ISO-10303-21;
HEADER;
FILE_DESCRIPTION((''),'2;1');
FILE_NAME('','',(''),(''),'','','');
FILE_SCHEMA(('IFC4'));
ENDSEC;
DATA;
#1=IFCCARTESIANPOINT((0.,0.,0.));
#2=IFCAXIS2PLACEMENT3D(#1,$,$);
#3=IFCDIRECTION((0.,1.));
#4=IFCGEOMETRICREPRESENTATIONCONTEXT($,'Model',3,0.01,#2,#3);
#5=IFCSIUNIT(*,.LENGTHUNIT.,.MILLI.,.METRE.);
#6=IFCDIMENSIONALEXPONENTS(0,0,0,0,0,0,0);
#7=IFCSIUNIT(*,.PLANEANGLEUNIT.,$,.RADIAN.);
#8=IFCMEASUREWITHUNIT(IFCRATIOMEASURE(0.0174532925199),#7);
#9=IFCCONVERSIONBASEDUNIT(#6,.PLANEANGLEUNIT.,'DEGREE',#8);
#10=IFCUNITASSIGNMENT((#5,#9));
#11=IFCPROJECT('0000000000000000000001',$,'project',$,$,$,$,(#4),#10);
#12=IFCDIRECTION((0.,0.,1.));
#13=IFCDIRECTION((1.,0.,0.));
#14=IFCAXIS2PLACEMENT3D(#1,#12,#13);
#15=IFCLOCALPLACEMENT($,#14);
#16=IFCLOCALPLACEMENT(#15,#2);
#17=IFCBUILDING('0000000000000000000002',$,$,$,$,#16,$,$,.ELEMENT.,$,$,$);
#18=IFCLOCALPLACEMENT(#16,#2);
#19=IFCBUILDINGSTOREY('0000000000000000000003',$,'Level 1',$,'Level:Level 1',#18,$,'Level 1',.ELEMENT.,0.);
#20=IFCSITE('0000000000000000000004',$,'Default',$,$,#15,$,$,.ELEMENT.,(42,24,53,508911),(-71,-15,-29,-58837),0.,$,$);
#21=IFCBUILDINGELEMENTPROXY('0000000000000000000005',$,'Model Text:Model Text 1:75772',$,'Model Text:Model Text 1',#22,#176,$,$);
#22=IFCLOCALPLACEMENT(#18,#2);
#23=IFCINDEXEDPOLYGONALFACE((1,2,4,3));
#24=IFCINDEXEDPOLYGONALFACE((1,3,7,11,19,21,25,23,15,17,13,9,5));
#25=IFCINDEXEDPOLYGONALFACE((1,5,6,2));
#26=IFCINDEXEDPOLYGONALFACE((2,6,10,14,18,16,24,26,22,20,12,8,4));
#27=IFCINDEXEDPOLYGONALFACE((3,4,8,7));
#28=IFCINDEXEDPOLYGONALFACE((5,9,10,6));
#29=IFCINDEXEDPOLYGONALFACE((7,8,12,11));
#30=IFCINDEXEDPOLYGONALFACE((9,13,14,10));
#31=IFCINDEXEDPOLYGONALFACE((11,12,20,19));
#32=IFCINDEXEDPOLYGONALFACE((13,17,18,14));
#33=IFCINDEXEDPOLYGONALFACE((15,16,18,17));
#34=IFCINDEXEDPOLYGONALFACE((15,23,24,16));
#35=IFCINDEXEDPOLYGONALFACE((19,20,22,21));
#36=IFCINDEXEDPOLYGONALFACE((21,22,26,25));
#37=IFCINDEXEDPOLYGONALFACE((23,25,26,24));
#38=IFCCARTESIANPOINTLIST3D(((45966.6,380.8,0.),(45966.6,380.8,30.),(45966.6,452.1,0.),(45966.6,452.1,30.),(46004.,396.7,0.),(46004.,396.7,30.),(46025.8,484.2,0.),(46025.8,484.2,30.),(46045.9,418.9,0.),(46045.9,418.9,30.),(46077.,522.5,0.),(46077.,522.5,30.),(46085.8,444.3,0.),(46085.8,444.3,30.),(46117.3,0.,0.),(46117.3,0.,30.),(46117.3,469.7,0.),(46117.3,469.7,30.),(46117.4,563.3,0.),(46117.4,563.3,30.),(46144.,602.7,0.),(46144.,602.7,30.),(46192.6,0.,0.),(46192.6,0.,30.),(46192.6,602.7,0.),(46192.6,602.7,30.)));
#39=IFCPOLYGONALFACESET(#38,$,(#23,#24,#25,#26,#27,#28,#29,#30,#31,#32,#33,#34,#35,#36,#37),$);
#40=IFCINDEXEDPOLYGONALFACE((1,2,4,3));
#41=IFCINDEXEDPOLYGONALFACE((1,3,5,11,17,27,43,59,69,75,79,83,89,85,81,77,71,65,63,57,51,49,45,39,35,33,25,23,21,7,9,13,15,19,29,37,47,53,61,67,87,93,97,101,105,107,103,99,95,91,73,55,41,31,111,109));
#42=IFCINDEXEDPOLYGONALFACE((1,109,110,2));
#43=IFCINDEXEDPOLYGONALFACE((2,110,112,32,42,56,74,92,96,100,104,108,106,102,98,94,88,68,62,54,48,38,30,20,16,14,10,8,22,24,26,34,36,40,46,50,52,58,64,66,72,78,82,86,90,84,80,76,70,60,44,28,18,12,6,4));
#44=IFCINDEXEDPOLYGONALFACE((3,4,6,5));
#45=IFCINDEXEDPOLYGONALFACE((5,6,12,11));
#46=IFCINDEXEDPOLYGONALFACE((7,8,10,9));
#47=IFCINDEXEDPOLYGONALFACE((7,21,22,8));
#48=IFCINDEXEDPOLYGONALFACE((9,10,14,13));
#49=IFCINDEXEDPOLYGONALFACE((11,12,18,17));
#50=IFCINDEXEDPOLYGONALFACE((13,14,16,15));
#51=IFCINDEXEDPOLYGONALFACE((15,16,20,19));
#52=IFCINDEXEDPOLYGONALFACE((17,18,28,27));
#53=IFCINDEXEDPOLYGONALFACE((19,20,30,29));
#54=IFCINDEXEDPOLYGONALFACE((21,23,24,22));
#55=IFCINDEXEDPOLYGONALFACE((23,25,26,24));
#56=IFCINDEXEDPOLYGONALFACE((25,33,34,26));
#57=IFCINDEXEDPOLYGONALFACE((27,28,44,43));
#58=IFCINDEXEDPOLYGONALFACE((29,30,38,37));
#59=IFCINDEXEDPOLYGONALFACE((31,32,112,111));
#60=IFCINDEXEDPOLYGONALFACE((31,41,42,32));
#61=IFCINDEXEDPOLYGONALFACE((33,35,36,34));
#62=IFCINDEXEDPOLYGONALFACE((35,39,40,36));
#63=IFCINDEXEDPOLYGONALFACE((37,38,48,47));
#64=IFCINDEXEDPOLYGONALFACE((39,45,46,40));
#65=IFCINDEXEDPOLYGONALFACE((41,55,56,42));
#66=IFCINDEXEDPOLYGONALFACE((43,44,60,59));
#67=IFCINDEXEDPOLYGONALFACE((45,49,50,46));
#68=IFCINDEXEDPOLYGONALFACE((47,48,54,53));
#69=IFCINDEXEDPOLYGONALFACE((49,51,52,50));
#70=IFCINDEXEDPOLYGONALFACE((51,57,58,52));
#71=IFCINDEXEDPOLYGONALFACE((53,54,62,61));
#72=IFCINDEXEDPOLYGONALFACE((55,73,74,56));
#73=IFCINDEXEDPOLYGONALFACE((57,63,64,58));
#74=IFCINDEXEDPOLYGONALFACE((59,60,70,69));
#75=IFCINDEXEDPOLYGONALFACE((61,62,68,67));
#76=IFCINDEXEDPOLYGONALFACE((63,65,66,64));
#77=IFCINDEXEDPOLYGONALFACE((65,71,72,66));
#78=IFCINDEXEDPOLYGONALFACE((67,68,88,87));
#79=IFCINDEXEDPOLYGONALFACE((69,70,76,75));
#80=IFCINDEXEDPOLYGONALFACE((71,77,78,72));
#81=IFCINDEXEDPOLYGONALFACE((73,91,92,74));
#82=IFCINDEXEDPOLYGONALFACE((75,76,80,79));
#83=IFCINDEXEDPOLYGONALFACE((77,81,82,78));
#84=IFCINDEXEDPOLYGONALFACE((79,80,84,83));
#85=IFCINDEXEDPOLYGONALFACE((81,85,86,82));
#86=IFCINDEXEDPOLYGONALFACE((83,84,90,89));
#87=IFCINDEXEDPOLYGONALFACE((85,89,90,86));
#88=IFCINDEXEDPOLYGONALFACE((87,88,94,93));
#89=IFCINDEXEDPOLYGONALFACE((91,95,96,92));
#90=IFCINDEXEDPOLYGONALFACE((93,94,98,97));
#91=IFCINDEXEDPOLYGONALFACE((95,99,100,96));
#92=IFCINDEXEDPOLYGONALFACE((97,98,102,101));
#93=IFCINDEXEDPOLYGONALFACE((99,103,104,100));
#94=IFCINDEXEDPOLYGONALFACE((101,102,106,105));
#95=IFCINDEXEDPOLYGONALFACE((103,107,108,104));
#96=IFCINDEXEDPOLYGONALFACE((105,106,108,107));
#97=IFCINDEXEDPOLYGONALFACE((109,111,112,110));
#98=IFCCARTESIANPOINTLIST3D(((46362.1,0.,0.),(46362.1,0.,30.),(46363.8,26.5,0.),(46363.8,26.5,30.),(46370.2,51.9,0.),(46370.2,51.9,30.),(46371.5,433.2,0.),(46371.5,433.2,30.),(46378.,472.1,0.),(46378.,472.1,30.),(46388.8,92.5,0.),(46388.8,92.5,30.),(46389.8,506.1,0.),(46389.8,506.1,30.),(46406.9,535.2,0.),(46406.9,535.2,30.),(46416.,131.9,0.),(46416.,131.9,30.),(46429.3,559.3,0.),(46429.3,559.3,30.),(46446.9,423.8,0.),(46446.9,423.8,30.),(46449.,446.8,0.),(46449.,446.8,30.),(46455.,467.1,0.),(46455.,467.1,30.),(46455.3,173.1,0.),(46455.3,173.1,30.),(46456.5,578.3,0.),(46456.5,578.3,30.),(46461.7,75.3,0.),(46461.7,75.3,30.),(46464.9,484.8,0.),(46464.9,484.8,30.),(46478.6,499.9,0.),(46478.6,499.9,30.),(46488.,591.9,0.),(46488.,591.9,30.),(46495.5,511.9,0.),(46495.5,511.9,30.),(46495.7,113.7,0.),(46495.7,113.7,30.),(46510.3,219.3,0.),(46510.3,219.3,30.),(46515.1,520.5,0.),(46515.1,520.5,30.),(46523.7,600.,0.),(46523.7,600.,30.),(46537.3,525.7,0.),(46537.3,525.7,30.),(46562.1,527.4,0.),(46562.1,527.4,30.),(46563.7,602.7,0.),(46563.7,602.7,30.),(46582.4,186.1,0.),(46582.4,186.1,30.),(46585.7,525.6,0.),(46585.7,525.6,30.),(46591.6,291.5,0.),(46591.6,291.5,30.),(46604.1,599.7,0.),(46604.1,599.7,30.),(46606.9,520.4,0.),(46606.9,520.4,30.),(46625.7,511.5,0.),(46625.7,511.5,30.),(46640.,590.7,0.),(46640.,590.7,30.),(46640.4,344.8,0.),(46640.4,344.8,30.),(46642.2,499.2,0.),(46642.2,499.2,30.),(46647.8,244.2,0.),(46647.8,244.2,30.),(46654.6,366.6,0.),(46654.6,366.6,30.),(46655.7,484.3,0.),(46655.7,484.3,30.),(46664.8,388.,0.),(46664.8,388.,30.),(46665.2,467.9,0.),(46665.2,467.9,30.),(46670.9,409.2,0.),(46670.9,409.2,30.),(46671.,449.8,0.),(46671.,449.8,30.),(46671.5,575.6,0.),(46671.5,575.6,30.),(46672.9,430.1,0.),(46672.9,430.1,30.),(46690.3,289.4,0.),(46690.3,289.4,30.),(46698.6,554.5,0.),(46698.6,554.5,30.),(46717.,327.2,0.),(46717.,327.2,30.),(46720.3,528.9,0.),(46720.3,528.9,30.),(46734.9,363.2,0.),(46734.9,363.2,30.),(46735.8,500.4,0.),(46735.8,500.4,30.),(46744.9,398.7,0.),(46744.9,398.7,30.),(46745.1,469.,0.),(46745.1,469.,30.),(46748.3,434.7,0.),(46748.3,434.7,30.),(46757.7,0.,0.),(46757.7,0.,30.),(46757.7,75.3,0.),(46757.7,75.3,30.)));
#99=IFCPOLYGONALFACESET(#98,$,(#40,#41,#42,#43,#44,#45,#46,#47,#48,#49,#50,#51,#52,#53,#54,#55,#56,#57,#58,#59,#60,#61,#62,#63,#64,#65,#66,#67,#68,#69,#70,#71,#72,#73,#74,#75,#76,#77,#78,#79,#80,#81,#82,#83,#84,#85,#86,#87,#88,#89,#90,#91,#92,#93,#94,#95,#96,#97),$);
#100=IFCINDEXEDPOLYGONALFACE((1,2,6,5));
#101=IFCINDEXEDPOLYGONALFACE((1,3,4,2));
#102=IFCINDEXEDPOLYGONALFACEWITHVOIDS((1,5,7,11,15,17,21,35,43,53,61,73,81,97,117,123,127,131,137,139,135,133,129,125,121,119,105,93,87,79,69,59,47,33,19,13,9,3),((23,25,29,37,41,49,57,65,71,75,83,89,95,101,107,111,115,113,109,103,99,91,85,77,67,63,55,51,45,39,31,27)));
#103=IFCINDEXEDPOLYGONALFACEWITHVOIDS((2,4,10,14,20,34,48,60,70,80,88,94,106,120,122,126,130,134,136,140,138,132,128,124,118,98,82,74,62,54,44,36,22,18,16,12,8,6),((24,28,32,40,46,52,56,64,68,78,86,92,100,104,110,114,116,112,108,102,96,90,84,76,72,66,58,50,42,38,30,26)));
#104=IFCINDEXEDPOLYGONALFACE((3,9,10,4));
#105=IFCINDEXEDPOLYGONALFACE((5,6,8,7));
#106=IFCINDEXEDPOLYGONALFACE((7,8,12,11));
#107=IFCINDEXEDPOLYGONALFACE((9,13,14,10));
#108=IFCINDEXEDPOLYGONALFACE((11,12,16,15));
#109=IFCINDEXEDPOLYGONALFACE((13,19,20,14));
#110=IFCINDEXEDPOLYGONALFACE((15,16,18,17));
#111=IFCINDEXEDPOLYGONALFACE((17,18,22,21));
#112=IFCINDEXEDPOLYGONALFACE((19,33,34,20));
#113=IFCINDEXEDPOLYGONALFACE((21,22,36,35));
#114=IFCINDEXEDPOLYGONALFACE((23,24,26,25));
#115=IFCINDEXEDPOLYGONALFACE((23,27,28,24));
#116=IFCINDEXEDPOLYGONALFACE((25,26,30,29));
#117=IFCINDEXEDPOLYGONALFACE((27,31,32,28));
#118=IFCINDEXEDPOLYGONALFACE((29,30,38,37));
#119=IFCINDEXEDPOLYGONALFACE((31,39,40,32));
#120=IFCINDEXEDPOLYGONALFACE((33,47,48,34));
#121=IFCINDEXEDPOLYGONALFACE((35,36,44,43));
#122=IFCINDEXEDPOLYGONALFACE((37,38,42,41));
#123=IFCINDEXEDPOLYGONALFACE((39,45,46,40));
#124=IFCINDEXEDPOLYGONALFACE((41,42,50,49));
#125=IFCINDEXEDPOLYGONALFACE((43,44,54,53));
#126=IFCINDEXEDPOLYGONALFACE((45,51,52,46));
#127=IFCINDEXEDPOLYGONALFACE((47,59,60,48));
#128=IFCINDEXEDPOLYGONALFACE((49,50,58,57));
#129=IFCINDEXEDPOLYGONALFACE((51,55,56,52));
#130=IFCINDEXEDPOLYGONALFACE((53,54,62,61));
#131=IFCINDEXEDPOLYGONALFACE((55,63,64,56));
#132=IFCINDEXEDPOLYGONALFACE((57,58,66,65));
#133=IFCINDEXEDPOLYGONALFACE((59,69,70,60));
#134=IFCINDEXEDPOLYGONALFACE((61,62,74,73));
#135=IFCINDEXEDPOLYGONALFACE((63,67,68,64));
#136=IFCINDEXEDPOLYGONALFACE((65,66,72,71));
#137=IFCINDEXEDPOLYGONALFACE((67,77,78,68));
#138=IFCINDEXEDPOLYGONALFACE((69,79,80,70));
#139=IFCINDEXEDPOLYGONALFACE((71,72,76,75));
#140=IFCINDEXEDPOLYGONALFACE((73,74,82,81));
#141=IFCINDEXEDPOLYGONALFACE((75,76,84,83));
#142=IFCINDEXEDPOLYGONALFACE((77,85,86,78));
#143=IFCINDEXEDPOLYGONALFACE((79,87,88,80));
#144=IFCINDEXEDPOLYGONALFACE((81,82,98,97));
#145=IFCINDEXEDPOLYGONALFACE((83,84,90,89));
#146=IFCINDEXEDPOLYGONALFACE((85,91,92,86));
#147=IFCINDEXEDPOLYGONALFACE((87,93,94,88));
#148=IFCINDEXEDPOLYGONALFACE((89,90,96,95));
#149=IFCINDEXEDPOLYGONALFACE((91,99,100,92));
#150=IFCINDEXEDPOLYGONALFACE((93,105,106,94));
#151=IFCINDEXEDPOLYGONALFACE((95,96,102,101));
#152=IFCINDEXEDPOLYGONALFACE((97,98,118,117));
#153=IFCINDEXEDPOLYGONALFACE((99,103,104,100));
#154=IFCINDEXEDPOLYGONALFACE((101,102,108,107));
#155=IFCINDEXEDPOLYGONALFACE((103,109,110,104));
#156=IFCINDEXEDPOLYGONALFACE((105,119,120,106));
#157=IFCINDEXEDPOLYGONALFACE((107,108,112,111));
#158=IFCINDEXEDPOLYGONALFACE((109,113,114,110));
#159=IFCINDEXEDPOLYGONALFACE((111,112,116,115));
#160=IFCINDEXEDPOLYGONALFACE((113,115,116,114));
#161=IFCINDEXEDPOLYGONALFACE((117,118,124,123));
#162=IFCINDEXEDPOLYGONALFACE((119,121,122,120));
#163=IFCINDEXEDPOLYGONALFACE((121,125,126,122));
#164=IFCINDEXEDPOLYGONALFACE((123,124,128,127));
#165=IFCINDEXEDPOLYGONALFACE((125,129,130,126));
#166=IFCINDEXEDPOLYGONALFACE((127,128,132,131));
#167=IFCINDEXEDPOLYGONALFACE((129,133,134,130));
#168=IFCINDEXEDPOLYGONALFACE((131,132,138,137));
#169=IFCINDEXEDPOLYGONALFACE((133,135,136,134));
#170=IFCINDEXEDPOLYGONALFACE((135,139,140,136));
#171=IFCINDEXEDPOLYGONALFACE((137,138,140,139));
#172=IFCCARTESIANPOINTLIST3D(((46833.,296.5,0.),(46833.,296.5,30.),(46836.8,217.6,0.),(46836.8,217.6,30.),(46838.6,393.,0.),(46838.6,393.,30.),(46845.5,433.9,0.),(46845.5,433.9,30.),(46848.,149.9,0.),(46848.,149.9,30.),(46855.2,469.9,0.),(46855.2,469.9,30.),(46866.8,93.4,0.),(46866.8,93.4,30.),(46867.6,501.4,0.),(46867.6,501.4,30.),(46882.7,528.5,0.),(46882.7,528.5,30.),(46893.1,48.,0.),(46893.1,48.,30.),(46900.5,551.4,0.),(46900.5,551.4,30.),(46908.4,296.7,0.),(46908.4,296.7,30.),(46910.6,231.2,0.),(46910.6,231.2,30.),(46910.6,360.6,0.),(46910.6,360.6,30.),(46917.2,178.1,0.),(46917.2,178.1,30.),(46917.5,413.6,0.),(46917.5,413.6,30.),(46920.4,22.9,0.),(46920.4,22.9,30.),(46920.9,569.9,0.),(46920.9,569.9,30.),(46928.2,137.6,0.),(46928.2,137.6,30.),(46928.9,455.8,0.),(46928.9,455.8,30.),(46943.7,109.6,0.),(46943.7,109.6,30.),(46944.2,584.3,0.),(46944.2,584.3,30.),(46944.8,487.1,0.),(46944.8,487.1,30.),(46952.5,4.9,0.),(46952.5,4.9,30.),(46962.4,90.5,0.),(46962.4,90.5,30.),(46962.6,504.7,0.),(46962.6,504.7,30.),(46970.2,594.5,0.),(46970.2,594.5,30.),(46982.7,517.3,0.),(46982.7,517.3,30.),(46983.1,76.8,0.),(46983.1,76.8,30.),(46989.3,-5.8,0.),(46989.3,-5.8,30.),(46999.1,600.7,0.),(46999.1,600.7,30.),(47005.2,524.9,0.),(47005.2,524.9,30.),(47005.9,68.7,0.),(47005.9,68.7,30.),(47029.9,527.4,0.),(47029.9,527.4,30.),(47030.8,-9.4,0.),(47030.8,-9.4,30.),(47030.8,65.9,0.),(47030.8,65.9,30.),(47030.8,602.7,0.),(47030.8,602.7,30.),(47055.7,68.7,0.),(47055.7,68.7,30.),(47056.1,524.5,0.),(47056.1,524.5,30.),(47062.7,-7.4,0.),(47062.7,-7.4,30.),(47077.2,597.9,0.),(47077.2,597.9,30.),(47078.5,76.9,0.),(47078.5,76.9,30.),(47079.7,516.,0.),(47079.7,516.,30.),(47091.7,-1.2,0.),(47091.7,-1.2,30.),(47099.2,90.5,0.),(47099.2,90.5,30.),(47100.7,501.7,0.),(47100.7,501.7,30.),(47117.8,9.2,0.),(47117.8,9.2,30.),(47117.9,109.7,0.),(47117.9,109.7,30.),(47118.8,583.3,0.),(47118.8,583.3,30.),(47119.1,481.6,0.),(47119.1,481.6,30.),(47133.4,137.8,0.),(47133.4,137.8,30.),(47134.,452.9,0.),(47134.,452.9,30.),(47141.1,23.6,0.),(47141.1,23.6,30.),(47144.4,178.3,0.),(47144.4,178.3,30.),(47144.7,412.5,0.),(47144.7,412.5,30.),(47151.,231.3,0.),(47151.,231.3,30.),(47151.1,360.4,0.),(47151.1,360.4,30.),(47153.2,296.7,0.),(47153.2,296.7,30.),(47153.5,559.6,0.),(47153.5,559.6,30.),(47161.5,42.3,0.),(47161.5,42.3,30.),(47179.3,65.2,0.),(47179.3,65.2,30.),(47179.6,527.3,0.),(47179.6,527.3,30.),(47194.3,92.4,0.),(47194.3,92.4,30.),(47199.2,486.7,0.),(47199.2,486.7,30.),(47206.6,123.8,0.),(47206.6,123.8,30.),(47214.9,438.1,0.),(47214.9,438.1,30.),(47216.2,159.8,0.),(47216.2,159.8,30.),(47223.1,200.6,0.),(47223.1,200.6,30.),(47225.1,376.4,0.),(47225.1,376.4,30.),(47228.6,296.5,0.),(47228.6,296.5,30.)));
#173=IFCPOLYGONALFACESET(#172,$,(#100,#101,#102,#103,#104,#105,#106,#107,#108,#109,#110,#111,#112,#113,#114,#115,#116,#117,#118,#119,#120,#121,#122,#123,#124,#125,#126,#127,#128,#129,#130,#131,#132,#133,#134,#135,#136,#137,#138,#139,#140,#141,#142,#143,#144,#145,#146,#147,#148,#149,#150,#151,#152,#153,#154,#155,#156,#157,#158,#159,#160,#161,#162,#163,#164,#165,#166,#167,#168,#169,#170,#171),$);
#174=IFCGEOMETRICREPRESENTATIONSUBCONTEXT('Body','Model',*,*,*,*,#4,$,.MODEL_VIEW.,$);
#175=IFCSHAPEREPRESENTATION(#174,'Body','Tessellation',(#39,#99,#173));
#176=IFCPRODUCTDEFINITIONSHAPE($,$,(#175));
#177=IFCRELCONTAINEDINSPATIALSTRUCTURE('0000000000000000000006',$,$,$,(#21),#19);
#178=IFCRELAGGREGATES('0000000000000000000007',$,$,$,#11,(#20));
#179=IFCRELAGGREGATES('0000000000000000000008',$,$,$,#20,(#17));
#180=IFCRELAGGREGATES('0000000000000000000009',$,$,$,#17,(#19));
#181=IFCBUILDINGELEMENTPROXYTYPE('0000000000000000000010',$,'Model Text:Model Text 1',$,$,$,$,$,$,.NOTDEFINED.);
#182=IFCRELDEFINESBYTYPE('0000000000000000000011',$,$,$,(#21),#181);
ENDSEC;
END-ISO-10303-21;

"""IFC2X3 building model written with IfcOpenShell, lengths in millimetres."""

from ifc_helpers import new_model, entity, si_unit, converted_unit, direction, frame, origin, origin_with_axes, place, context, subcontext, project, spatial, polyline, outline, extrude, type_object, element, save


model = new_model("IFC2X3")

# Units and contexts
model_context = context("Model", 3, precision=0.01, world=origin(), true_north=direction((0.0, 1.0)))
body_context = subcontext(model_context, "Body", "Model", "MODEL_VIEW")
ifc_project = project(units=[si_unit("LENGTHUNIT", "METRE", prefix="MILLI"), converted_unit("PLANEANGLEUNIT", "DEGREE", entity("IfcRatioMeasure", 0.0174532925199), si_unit("PLANEANGLEUNIT", "RADIAN"), dimensions=[0, 0, 0, 0, 0, 0, 0])], contexts=[model_context])

# Site, building, storey
site_placement = place(None, origin_with_axes())
site = spatial("IfcSite", under=ifc_project, at=site_placement, Name="Default", CompositionType="ELEMENT", RefLatitude=(42, 24, 53, 508911), RefLongitude=(-71, -15, -29, -58837), RefElevation=0.0)
building_placement = place(site_placement, origin())
building = spatial("IfcBuilding", under=site, at=building_placement, CompositionType="ELEMENT")
storey_placement = place(building_placement, origin())
storey = spatial("IfcBuildingStorey", under=building, at=storey_placement, Name="Level 1", ObjectType="Level:Level 1", LongName="Level 1", CompositionType="ELEMENT", Elevation=0.0)

# Building element proxy
building_element_proxy_type_1 = type_object("IfcBuildingElementProxyType", Name="Model Text:Model Text 1", PredefinedType="NOTDEFINED")
proxy_1_placement = place(storey_placement, frame((45966.6, -9.4, 0.0)))
element("IfcBuildingElementProxy", 1, at=proxy_1_placement, inside=storey, type_object=building_element_proxy_type_1, Name="Model Text:Model Text 1:75772", ObjectType="Model Text:Model Text 1", context=body_context, shape_type="SweptSolid", body=[
    extrude(outline(polyline([(-410.6, -111.6), (192.1, -111.6), (192.1, -63.1), (152.7, -36.4), (111.9, 4.0), (73.6, 55.2), (41.4, 114.4), (-29.8, 114.4), (-13.9, 77.0), (8.3, 35.1), (33.7, -4.8), (59.1, -36.3), (-410.6, -36.3), (-410.6, -111.6)])), frame((114.4, 420.0, 0.0), z_axis=(0.0, 0.0, 1.0), x_axis=(0.0, 1.0, 0.0)), (0.0, 0.0, 1.0), 30.0),
    extrude(outline(polyline([(-190.2, -317.5), (-190.2, -392.8), (205.4, -392.8), (203.7, -366.3), (197.3, -340.9), (178.7, -300.3), (151.5, -260.9), (112.2, -219.7), (57.2, -173.6), (-24.1, -101.3), (-72.9, -48.0), (-87.1, -26.3), (-97.3, -4.8), (-103.4, 16.4), (-105.4, 37.3), (-103.5, 57.0), (-97.7, 75.0), (-88.2, 91.5), (-74.7, 106.4), (-58.2, 118.7), (-39.4, 127.5), (-18.2, 132.8), (5.4, 134.6), (30.2, 132.9), (52.4, 127.7), (72.0, 119.1), (88.9, 107.1), (102.6, 92.0), (112.5, 74.3), (118.5, 54.0), (120.6, 31.0), (196.0, 40.4), (189.5, 79.3), (177.7, 113.3), (160.6, 142.4), (138.2, 166.5), (111.0, 185.5), (79.5, 199.1), (43.8, 207.2), (3.8, 209.9), (-36.6, 206.9), (-72.5, 197.9), (-104.0, 182.8), (-131.1, 161.7), (-152.8, 136.1), (-168.3, 107.6), (-177.6, 76.2), (-180.8, 41.9), (-177.4, 5.8), (-167.4, -29.6), (-149.5, -65.6), (-122.8, -103.4), (-80.3, -148.6), (-14.9, -206.7), (71.8, -279.1), (105.8, -317.5), (-190.2, -317.5)])), frame((600.9, 402.2, 0.0), z_axis=(0.0, 0.0, -1.0), x_axis=(-1.0, 0.0, 0.0)), (0.0, 0.0, -1.0), 30.0),
    extrude(outline(polyline([(-10.6, -198.7), (68.3, -198.7), (136.5, -190.7), (193.9, -174.7), (240.5, -150.6), (266.9, -124.4), (286.3, -93.2), (298.8, -57.0), (304.3, -15.7), (303.8, 16.2), (299.0, 45.5), (289.9, 72.1), (276.6, 96.0), (258.9, 117.3), (236.9, 136.2), (210.4, 152.5), (179.6, 166.3), (144.1, 177.6), (103.7, 186.3), (8.2, 196.4), (-71.8, 196.7), (-134.0, 189.4), (-183.3, 176.1), (-224.7, 158.4), (-258.2, 133.9), (-283.5, 100.3), (-300.1, 59.5), (-307.1, 13.4), (-306.6, -18.4), (-301.8, -47.5), (-292.8, -74.0), (-279.6, -97.9), (-262.0, -119.2), (-240.0, -138.1), (-213.6, -154.5), (-182.8, -168.4), (-147.3, -179.8), (-106.7, -188.6), (-10.6, -198.7)]), holes=[polyline([(-7.2, -123.5), (-71.0, -118.2), (-123.6, -108.8), (-165.2, -95.4), (-195.7, -78.0), (-212.4, -59.4), (-224.1, -38.7), (-230.6, -15.9), (-231.9, 8.9), (-227.8, 35.0), (-218.1, 58.1), (-202.8, 78.4), (-182.0, 95.8), (-152.6, 109.4), (-111.7, 118.1), (-59.4, 122.0), (4.4, 121.1), (69.6, 115.8), (122.2, 106.7), (162.2, 93.7), (189.5, 77.0), (207.7, 57.4), (220.4, 36.0), (227.5, 12.8), (229.1, -12.1), (225.2, -36.8), (215.9, -59.2), (201.3, -79.3), (181.4, -97.1), (152.6, -111.2), (111.6, -120.3), (58.3, -124.4), (-7.2, -123.5)])]), frame((1065.4, 304.7, 0.0), z_axis=(0.0, 0.0, 1.0), x_axis=(0.047515, -0.998871, 0.0)), (0.0, 0.0, 1.0), 30.0),
])

save(model, "model.ifc")
